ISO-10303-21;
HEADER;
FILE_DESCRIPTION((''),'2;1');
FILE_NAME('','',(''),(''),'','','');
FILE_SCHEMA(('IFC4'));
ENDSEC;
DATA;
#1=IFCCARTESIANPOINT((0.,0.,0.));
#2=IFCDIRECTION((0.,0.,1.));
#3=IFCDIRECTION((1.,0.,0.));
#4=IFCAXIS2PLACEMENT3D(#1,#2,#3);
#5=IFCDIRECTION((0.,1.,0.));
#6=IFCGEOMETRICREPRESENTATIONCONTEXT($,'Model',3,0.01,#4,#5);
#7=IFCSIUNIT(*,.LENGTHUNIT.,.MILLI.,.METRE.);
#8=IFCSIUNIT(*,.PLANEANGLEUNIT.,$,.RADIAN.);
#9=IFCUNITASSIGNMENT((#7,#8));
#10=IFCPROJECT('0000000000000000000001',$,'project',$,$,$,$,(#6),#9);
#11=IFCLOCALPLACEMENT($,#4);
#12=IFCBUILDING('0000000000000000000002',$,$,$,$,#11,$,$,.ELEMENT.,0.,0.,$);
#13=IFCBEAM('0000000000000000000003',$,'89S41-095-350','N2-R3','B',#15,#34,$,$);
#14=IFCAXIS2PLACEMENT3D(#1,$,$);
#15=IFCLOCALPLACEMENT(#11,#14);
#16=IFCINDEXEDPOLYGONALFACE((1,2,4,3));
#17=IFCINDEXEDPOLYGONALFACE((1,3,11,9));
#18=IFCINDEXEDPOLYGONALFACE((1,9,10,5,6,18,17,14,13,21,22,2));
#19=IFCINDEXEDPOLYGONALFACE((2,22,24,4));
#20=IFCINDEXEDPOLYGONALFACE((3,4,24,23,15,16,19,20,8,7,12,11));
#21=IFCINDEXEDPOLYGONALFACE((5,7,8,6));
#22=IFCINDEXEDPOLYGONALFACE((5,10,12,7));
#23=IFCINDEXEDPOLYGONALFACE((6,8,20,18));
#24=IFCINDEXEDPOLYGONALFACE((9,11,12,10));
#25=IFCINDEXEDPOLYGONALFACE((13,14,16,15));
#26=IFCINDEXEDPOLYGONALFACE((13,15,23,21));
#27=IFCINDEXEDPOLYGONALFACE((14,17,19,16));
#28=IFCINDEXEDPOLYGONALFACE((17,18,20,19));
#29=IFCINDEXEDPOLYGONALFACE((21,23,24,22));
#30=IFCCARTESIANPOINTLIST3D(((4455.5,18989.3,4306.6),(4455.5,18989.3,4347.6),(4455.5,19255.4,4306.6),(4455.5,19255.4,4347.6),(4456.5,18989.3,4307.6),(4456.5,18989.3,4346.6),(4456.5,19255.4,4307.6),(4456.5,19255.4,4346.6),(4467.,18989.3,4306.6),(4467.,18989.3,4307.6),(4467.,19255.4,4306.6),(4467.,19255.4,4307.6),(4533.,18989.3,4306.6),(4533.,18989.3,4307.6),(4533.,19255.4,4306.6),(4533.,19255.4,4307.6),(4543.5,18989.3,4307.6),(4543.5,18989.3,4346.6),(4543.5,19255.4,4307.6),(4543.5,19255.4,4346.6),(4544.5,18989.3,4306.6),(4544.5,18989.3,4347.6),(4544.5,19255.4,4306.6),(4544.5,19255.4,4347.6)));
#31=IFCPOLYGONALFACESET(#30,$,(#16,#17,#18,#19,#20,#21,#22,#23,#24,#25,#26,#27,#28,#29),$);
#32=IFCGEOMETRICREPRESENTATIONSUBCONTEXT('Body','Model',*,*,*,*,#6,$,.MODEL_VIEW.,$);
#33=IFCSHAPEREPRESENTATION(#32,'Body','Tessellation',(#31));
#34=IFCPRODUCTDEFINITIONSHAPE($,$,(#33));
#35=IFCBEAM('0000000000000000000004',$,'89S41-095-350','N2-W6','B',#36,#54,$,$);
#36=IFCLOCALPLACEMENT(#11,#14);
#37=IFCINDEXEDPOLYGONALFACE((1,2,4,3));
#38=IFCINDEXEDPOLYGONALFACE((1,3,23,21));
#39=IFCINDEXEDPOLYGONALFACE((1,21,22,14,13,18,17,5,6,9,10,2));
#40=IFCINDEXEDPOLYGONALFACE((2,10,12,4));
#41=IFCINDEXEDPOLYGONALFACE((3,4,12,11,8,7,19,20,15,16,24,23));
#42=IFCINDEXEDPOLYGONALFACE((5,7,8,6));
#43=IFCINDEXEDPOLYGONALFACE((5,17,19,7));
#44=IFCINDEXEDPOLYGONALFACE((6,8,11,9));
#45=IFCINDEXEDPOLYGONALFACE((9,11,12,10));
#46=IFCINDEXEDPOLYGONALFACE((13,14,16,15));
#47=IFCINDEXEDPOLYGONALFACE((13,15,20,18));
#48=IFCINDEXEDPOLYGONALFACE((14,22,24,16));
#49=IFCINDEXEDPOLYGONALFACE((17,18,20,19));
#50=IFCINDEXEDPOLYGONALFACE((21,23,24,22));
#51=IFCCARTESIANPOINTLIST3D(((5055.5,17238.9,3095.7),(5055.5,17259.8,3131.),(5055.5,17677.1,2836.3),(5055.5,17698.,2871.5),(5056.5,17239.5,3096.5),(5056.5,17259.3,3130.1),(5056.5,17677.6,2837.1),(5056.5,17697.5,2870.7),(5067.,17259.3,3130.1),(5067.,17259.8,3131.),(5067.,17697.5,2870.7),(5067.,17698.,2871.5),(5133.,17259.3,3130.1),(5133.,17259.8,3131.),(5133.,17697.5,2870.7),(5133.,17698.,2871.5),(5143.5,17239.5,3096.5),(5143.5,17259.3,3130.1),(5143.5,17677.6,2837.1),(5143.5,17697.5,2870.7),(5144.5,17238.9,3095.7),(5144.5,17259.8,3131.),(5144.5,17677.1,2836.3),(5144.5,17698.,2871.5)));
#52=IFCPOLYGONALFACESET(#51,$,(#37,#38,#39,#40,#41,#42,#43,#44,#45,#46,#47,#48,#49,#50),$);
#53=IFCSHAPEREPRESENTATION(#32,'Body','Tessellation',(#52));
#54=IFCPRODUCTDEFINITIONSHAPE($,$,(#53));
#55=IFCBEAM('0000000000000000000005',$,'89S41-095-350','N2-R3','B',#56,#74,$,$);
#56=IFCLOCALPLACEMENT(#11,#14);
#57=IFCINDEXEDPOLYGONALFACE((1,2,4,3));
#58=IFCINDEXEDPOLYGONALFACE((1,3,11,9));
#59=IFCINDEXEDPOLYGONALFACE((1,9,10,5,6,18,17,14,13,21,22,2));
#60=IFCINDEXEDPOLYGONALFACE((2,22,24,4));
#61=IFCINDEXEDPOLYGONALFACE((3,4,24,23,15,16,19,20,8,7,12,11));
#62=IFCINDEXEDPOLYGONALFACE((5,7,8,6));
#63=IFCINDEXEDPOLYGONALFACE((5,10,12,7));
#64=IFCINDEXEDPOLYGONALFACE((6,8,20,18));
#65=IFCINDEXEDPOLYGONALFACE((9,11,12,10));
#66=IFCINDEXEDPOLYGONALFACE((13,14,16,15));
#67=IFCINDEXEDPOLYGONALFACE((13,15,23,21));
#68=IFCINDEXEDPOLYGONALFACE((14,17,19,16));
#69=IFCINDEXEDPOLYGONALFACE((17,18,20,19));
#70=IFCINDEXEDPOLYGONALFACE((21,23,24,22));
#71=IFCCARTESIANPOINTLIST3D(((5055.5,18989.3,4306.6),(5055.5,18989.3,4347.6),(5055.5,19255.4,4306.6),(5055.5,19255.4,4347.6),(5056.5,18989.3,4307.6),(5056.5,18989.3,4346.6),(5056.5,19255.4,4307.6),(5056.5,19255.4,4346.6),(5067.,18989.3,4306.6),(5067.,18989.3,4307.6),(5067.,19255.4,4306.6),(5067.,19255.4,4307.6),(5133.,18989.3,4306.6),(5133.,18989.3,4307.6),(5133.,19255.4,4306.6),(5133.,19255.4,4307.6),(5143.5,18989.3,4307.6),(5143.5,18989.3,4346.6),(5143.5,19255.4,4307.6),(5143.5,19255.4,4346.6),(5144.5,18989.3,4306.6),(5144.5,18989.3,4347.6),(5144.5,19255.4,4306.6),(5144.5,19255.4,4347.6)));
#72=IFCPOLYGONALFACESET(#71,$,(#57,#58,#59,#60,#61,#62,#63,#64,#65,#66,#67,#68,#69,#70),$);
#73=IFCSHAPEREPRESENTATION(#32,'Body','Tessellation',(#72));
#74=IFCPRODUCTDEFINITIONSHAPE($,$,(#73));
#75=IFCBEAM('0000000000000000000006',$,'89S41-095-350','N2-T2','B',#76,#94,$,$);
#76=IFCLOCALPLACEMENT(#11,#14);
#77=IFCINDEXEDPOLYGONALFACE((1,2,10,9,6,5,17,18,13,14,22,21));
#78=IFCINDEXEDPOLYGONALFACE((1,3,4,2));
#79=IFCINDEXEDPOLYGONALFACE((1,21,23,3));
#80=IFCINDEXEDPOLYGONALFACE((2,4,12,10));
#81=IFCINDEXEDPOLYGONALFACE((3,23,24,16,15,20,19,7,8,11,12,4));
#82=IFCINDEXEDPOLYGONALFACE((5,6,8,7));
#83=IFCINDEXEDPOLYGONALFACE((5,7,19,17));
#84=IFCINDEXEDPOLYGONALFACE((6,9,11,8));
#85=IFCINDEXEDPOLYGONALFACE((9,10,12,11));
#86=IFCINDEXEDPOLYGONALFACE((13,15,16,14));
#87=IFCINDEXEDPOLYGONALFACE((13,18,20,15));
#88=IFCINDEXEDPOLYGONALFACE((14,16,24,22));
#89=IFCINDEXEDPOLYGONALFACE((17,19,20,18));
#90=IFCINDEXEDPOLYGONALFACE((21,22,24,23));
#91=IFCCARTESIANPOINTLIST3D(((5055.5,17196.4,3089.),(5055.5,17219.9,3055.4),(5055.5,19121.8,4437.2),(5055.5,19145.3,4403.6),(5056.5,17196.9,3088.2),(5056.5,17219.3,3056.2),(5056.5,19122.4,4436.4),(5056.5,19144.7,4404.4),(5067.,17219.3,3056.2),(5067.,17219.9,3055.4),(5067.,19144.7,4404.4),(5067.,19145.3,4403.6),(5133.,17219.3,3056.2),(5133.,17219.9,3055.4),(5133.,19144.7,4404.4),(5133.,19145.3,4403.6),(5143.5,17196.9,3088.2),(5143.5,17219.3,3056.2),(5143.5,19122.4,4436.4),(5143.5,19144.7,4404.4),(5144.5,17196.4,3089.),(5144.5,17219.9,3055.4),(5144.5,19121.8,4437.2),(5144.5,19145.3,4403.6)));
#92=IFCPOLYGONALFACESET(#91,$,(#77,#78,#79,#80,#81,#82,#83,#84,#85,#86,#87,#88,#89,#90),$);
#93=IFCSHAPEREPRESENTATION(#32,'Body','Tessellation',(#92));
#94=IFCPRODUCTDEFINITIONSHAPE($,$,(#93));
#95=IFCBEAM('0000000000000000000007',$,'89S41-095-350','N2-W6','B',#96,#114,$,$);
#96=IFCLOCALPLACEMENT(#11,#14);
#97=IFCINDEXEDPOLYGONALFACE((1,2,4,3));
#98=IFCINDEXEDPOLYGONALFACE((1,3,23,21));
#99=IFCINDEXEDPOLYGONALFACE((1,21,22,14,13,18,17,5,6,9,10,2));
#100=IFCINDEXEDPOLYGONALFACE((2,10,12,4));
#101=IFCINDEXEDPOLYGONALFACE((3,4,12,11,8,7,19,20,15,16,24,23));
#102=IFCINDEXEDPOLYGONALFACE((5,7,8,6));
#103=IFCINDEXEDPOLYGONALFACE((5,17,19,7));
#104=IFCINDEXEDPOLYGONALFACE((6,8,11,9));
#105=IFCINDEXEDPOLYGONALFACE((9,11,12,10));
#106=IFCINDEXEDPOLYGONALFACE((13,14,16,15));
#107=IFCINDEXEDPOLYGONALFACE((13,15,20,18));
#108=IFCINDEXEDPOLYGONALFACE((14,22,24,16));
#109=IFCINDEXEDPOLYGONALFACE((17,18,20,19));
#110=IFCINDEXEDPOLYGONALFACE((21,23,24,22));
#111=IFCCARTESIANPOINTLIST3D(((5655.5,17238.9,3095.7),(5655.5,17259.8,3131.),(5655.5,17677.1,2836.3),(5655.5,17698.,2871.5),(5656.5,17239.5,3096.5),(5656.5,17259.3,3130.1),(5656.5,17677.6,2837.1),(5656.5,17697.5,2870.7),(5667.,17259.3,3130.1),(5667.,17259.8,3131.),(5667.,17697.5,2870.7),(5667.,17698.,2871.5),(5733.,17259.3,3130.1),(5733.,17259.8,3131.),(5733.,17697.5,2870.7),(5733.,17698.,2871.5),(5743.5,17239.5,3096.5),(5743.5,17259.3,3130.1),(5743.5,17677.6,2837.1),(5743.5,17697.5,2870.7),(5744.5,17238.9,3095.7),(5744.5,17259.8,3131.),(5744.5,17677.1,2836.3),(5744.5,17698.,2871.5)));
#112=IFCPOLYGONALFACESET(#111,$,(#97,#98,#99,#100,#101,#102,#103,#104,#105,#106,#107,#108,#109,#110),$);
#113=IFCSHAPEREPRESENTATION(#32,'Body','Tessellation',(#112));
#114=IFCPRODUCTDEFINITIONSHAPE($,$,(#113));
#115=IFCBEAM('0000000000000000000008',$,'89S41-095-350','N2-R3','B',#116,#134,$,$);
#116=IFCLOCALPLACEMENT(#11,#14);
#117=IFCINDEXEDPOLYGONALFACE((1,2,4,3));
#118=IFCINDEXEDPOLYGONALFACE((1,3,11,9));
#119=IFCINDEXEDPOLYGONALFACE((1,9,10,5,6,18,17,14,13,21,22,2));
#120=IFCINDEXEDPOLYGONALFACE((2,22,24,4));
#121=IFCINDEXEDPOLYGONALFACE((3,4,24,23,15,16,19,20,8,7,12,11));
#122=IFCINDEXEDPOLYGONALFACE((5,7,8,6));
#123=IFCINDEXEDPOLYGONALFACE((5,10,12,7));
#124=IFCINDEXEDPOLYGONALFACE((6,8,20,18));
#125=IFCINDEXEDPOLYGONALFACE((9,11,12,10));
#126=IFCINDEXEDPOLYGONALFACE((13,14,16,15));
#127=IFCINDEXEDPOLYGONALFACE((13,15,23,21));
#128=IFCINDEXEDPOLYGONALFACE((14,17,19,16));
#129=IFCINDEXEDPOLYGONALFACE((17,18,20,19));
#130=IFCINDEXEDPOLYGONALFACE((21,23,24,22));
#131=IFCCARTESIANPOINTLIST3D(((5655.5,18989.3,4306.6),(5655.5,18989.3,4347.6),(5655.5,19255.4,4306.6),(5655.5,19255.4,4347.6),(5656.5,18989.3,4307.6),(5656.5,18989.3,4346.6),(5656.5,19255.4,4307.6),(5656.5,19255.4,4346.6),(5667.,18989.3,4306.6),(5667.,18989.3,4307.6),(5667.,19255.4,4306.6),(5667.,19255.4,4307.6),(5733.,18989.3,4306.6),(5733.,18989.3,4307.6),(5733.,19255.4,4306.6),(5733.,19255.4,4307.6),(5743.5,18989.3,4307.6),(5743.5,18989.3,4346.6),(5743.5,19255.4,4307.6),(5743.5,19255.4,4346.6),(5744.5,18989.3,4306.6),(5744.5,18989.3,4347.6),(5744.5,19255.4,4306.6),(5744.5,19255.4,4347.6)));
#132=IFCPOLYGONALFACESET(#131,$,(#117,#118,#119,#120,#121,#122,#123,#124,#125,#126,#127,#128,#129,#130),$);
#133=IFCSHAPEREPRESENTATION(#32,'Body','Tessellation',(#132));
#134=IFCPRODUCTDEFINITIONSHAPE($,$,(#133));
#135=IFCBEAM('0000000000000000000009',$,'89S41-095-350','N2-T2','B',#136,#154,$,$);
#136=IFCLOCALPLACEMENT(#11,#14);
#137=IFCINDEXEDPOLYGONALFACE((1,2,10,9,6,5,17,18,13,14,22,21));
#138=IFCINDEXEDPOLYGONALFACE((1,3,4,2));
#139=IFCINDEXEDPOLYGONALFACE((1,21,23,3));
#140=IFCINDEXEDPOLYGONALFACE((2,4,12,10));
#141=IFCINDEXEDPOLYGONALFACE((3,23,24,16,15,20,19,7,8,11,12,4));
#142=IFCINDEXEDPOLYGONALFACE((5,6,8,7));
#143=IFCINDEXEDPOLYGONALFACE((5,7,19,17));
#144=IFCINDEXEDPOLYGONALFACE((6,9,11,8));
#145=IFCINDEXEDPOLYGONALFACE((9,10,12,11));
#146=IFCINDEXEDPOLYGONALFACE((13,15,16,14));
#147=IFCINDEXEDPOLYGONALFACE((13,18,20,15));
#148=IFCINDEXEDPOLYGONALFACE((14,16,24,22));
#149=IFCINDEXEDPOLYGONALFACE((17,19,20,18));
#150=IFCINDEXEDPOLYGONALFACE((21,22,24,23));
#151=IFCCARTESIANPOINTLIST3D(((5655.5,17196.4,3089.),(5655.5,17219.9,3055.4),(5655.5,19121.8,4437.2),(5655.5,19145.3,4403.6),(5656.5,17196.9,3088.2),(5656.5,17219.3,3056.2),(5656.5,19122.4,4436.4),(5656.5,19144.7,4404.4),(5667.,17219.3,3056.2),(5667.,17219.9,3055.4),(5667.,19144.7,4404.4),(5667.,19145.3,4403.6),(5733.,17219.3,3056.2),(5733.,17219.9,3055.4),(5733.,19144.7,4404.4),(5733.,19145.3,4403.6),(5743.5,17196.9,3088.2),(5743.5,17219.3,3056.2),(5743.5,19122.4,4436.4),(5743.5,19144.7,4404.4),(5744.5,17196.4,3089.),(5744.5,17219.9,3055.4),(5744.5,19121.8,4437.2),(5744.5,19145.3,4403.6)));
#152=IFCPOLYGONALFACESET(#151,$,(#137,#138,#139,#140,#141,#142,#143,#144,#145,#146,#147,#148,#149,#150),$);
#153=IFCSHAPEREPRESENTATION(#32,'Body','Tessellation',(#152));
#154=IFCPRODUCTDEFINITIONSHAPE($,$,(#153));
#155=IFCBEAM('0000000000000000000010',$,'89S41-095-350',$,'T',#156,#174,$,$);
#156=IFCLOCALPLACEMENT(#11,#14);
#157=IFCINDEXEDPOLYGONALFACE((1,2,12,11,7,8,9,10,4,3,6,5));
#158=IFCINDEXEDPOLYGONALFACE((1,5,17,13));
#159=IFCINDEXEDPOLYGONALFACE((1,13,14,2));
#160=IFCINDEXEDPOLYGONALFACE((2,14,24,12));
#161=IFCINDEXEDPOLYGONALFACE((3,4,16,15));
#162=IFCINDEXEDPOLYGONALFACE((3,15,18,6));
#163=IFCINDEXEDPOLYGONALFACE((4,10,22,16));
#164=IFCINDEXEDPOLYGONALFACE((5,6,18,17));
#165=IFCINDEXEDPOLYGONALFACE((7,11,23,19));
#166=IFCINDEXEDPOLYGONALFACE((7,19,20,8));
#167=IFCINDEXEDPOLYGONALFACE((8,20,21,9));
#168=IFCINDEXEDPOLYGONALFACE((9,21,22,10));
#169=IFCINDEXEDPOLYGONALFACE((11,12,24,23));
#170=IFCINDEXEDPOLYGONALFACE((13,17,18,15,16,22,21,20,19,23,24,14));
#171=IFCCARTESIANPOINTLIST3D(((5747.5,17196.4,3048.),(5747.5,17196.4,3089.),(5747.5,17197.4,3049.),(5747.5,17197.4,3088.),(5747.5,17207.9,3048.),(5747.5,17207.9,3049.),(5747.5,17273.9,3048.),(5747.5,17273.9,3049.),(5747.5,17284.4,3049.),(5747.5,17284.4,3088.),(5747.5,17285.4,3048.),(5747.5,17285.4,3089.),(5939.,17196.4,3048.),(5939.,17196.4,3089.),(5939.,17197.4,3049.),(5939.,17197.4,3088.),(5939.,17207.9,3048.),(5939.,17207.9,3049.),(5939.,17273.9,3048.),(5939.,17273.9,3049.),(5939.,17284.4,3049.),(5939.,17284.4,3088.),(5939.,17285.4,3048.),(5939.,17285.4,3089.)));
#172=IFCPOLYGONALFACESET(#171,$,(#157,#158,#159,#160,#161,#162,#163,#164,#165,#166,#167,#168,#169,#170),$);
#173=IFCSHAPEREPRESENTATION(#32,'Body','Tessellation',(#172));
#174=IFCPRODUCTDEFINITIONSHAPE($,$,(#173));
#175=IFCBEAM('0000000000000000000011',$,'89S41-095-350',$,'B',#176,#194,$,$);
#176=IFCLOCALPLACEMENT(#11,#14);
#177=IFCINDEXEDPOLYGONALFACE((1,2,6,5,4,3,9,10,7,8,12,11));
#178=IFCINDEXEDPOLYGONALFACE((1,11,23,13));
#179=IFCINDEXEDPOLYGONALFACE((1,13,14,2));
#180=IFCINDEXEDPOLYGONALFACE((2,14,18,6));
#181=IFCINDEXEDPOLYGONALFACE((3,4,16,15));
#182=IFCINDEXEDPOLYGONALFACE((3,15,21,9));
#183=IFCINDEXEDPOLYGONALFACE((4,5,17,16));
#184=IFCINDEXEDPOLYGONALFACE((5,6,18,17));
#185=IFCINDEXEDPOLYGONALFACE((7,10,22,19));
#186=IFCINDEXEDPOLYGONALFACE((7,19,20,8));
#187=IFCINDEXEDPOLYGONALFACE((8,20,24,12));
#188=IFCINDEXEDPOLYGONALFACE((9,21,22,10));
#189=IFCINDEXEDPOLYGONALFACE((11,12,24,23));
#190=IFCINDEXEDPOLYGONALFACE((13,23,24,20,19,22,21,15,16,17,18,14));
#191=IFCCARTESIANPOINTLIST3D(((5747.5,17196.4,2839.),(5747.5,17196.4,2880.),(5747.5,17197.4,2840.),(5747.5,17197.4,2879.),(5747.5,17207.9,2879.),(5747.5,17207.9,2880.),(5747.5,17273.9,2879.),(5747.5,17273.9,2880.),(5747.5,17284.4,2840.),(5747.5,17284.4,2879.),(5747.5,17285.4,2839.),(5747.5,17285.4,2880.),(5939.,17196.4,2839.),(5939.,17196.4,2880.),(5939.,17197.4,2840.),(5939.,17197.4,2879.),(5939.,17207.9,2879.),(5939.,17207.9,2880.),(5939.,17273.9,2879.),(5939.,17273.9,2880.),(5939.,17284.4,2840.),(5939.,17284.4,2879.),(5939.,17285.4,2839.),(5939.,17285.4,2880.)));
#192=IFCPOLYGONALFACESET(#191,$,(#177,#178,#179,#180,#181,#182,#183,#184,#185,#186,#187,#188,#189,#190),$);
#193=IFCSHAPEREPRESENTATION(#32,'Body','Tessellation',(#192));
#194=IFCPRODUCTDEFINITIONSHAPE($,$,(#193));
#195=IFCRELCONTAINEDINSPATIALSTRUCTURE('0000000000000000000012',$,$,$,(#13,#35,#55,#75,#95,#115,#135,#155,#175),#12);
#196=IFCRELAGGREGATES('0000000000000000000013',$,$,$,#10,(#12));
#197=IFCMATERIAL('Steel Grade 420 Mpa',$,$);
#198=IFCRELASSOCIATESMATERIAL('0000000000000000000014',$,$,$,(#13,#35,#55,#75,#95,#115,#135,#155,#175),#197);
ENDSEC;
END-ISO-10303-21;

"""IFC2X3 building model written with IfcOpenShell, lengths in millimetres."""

from ifc_helpers import new_model, si_unit, direction, frame, origin, origin_with_axes, origin_2d_with_axis, place, context, subcontext, project, spatial, c_section, extrude, source, transform, mapped, material, element, save


model = new_model("IFC2X3")

# Units and contexts
model_context = context("Model", 3, precision=0.01, world=origin_with_axes(), true_north=direction((0.0, 1.0, 0.0)))
body_context = subcontext(model_context, "Body", "Model", "MODEL_VIEW")
ifc_project = project(units=[si_unit("LENGTHUNIT", "METRE", prefix="MILLI"), si_unit("PLANEANGLEUNIT", "RADIAN")], contexts=[model_context])

# Building
building_placement = place(None, origin_with_axes())
building = spatial("IfcBuilding", under=ifc_project, at=building_placement, CompositionType="ELEMENT", ElevationOfRefHeight=0.0, ElevationOfTerrain=0.0)

# Shared definitions
ifc_material = material(Name="Steel Grade 420 Mpa")

# Beams
shared_shape_1 = source(origin(), body_context, "Body", "SweptSolid", [
    extrude(c_section(Depth=89.0, Width=41.0, WallThickness=1.0, Girth=11.5, at=origin_2d_with_axis()), origin_with_axes(), (0.0, 0.0, 1.0), 266.1),
])
beam_1_placement = place(None, frame((4500.0, 18989.3, 4327.1), z_axis=(0.0, 1.0, 0.0), x_axis=(0.0, 0.0, -1.0)))
element("IfcBeam", 1, at=beam_1_placement, inside=building, material=ifc_material, Name="89S41-095-350", Description="N2-R3", ObjectType="B", context=body_context, shape_type="MappedRepresentation", body=[
    mapped(shared_shape_1, transform((0.0, 0.0, 0.0), scale=1.0)),
])
shared_shape_2 = source(origin(), body_context, "Body", "SweptSolid", [
    extrude(c_section(Depth=89.0, Width=41.0, WallThickness=1.0, Girth=11.5, at=origin_2d_with_axis()), origin_with_axes(), (0.0, 0.0, 1.0), 509.2),
])
beam_2_placement = place(None, frame((5100.0, 17687.6, 2853.9), z_axis=(0.0, -0.860497, 0.509455), x_axis=(0.0, 0.509455, 0.860497)))
element("IfcBeam", 2, at=beam_2_placement, inside=building, material=ifc_material, Name="89S41-095-350", Description="N2-W6", ObjectType="B", context=body_context, shape_type="MappedRepresentation", body=[
    mapped(shared_shape_2, transform((0.0, 0.0, 0.0), scale=1.0)),
])
shared_shape_3 = source(origin(), body_context, "Body", "SweptSolid", [
    extrude(c_section(Depth=89.0, Width=41.0, WallThickness=1.0, Girth=11.5, at=origin_2d_with_axis()), origin_with_axes(), (0.0, 0.0, 1.0), 266.1),
])
beam_3_placement = place(None, frame((5100.0, 18989.3, 4327.1), z_axis=(0.0, 1.0, 0.0), x_axis=(0.0, 0.0, -1.0)))
element("IfcBeam", 3, at=beam_3_placement, inside=building, material=ifc_material, Name="89S41-095-350", Description="N2-R3", ObjectType="B", context=body_context, shape_type="MappedRepresentation", body=[
    mapped(shared_shape_3, transform((0.0, 0.0, 0.0), scale=1.0)),
])
shared_shape_4 = source(origin(), body_context, "Body", "SweptSolid", [
    extrude(c_section(Depth=89.0, Width=41.0, WallThickness=1.0, Girth=11.5, at=origin_2d_with_axis()), origin_with_axes(), (0.0, 0.0, 1.0), 2350.5),
])
beam_4_placement = place(None, frame((5100.0, 17208.1, 3072.2), z_axis=(0.0, 0.819152, 0.573576), x_axis=(0.0, 0.573576, -0.819152)))
element("IfcBeam", 4, at=beam_4_placement, inside=building, material=ifc_material, Name="89S41-095-350", Description="N2-T2", ObjectType="B", context=body_context, shape_type="MappedRepresentation", body=[
    mapped(shared_shape_4, transform((0.0, 0.0, 0.0), scale=1.0)),
])
shared_shape_5 = source(origin(), body_context, "Body", "SweptSolid", [
    extrude(c_section(Depth=89.0, Width=41.0, WallThickness=1.0, Girth=11.5, at=origin_2d_with_axis()), origin_with_axes(), (0.0, 0.0, 1.0), 509.2),
])
beam_5_placement = place(None, frame((5700.0, 17687.6, 2853.9), z_axis=(0.0, -0.860497, 0.509455), x_axis=(0.0, 0.509455, 0.860497)))
element("IfcBeam", 5, at=beam_5_placement, inside=building, material=ifc_material, Name="89S41-095-350", Description="N2-W6", ObjectType="B", context=body_context, shape_type="MappedRepresentation", body=[
    mapped(shared_shape_5, transform((0.0, 0.0, 0.0), scale=1.0)),
])
shared_shape_6 = source(origin(), body_context, "Body", "SweptSolid", [
    extrude(c_section(Depth=89.0, Width=41.0, WallThickness=1.0, Girth=11.5, at=origin_2d_with_axis()), origin_with_axes(), (0.0, 0.0, 1.0), 266.1),
])
beam_6_placement = place(None, frame((5700.0, 18989.3, 4327.1), z_axis=(0.0, 1.0, 0.0), x_axis=(0.0, 0.0, -1.0)))
element("IfcBeam", 6, at=beam_6_placement, inside=building, material=ifc_material, Name="89S41-095-350", Description="N2-R3", ObjectType="B", context=body_context, shape_type="MappedRepresentation", body=[
    mapped(shared_shape_6, transform((0.0, 0.0, 0.0), scale=1.0)),
])
shared_shape_7 = source(origin(), body_context, "Body", "SweptSolid", [
    extrude(c_section(Depth=89.0, Width=41.0, WallThickness=1.0, Girth=11.5, at=origin_2d_with_axis()), origin_with_axes(), (0.0, 0.0, 1.0), 2350.5),
])
beam_7_placement = place(None, frame((5700.0, 17208.1, 3072.2), z_axis=(0.0, 0.819152, 0.573576), x_axis=(0.0, 0.573576, -0.819152)))
element("IfcBeam", 7, at=beam_7_placement, inside=building, material=ifc_material, Name="89S41-095-350", Description="N2-T2", ObjectType="B", context=body_context, shape_type="MappedRepresentation", body=[
    mapped(shared_shape_7, transform((0.0, 0.0, 0.0), scale=1.0)),
])
shared_shape_8 = source(origin(), body_context, "Body", "SweptSolid", [
    extrude(c_section(Depth=89.0, Width=41.0, WallThickness=1.0, Girth=11.5, at=origin_2d_with_axis()), origin_with_axes(), (0.0, 0.0, 1.0), 191.5),
])
beam_8_placement = place(None, frame((5939.0, 17240.9, 3068.5), z_axis=(-1.0, 0.0, 0.0), x_axis=(0.0, 0.0, -1.0)))
element("IfcBeam", 8, at=beam_8_placement, inside=building, material=ifc_material, Name="89S41-095-350", ObjectType="T", context=body_context, shape_type="MappedRepresentation", body=[
    mapped(shared_shape_8, transform((0.0, 0.0, 0.0), scale=1.0)),
])
shared_shape_9 = source(origin(), body_context, "Body", "SweptSolid", [
    extrude(c_section(Depth=89.0, Width=41.0, WallThickness=1.0, Girth=11.5, at=origin_2d_with_axis()), origin_with_axes(), (0.0, 0.0, 1.0), 191.5),
])
beam_9_placement = place(None, frame((5747.5, 17240.9, 2859.5), z_axis=(1.0, 0.0, 0.0), x_axis=(0.0, 0.0, 1.0)))
element("IfcBeam", 9, at=beam_9_placement, inside=building, material=ifc_material, Name="89S41-095-350", ObjectType="B", context=body_context, shape_type="MappedRepresentation", body=[
    mapped(shared_shape_9, transform((0.0, 0.0, 0.0), scale=1.0)),
])

save(model, "model.ifc")
